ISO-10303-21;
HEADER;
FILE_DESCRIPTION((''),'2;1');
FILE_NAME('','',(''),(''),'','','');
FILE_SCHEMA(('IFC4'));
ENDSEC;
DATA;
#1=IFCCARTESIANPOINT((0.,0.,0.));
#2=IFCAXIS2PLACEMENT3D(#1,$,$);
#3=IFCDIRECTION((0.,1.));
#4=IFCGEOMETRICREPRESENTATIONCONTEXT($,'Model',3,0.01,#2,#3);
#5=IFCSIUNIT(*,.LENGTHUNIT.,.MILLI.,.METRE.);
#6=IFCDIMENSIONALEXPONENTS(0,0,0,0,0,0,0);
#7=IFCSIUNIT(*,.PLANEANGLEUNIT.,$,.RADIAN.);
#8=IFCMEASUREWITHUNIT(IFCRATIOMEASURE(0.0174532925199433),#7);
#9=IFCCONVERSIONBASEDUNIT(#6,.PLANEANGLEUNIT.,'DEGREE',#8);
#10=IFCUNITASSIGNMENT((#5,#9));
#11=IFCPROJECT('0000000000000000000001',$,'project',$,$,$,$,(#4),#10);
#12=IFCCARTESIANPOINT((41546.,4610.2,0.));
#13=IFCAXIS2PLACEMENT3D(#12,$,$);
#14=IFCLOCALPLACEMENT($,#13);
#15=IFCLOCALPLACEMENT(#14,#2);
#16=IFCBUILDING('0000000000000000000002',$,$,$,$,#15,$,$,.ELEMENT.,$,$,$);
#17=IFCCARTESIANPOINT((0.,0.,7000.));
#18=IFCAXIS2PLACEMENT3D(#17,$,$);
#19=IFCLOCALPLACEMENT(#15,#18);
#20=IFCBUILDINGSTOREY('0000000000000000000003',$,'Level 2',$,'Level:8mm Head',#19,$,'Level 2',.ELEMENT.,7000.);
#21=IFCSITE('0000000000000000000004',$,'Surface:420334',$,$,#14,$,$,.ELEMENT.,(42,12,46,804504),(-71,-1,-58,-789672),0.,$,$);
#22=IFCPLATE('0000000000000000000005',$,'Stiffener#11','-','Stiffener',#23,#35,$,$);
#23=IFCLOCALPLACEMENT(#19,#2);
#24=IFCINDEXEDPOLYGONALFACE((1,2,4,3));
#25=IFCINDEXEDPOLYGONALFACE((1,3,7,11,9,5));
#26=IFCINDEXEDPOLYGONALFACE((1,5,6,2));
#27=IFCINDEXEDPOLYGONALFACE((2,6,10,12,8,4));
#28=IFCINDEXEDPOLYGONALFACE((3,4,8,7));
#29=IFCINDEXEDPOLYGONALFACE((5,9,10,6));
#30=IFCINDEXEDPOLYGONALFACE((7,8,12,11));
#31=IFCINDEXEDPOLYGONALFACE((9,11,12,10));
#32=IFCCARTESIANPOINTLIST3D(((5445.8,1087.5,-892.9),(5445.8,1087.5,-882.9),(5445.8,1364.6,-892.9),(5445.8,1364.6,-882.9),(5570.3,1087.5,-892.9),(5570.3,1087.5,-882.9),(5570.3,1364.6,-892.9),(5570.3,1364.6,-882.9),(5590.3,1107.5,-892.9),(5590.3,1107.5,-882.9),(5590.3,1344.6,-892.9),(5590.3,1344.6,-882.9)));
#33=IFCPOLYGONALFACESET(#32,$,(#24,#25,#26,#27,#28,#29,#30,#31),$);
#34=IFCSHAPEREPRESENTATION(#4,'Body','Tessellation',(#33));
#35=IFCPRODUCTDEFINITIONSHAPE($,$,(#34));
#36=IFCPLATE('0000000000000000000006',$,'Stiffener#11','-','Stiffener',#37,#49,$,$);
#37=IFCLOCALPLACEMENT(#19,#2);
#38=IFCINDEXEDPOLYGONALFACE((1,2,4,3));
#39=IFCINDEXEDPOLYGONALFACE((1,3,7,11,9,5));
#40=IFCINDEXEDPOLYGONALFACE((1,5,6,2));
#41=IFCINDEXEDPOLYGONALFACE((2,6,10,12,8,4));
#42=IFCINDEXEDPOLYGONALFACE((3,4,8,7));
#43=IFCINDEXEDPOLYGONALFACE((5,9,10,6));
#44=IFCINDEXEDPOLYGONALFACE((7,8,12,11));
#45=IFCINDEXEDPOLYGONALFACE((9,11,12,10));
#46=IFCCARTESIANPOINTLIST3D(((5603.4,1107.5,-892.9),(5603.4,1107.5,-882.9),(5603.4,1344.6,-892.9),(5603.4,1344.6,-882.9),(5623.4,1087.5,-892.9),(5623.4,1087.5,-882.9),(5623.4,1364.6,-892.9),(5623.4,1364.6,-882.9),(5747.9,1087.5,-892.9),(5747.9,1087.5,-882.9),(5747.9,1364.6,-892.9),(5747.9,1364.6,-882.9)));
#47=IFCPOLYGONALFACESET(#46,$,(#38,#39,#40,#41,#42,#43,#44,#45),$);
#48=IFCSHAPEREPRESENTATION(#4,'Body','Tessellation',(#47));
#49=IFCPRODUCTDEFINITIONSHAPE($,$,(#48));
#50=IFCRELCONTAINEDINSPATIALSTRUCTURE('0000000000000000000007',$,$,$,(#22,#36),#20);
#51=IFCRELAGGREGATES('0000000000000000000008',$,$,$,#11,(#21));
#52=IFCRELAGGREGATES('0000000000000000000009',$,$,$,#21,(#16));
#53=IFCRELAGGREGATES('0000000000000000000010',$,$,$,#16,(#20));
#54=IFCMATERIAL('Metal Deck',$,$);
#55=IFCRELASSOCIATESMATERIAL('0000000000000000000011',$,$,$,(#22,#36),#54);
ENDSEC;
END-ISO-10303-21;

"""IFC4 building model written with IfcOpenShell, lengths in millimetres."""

from ifc_helpers import new_model, entity, si_unit, converted_unit, direction, frame, origin, origin_with_axes, place, context, project, spatial, polyline, outline, extrude, material, element, save


model = new_model("IFC4")

# Units and contexts
model_context = context("Model", 3, precision=0.01, world=origin(), true_north=direction((0.0, 1.0)))
ifc_project = project(units=[si_unit("LENGTHUNIT", "METRE", prefix="MILLI"), converted_unit("PLANEANGLEUNIT", "DEGREE", entity("IfcRatioMeasure", 0.0174532925199433), si_unit("PLANEANGLEUNIT", "RADIAN"), dimensions=[0, 0, 0, 0, 0, 0, 0])], contexts=[model_context])

# Site, building, storey
site_placement = place(None, frame((41546.0, 4610.2, 0.0)))
site = spatial("IfcSite", under=ifc_project, at=site_placement, Name="Surface:420334", CompositionType="ELEMENT", RefLatitude=(42, 12, 46, 804504), RefLongitude=(-71, -1, -58, -789672), RefElevation=0.0)
building_placement = place(site_placement, origin())
building = spatial("IfcBuilding", under=site, at=building_placement, CompositionType="ELEMENT")
storey_placement = place(building_placement, frame((0.0, 0.0, 7000.0)))
storey = spatial("IfcBuildingStorey", under=building, at=storey_placement, Name="Level 2", ObjectType="Level:8mm Head", LongName="Level 2", CompositionType="ELEMENT", Elevation=7000.0)

# Plates, openings
ifc_material_1 = material(Name="Metal Deck")
plate_1_placement = place(storey_placement, frame((5445.8, 1087.5, -882.9), z_axis=(0.0, 0.0, -1.0), x_axis=(0.0, 1.0, 0.0)))
plate_1 = element("IfcPlate", 1, at=plate_1_placement, inside=storey, material=ifc_material_1, Name="Stiffener#11", Description="-", ObjectType="Stiffener", context=model_context, shape_type="SweptSolid", body=[
    extrude(outline(polyline([(0.0, 0.0), (277.1, 0.0), (277.1, 144.5), (0.0, 144.5), (0.0, 0.0)])), origin_with_axes(), (0.0, 0.0, 1.0), 10.0),
])
opening_1_placement = place(plate_1_placement, frame((0.0, 0.0, 0.0), z_axis=(0.0, 0.0, 1.0), x_axis=(1.0, 0.0, 0.0)))
element("IfcOpeningElement", 2, at=opening_1_placement, cuts=plate_1, ObjectType="Opening", context=model_context, shape_type="SweptSolid", body=[
    extrude(outline(polyline([(277.1, 144.5), (257.1, 144.5), (277.1, 124.5), (277.1, 144.5)])), origin(), (0.0, 0.0, 1.0), 10.0),
])
opening_2_placement = place(plate_1_placement, frame((0.0, 0.0, 0.0), z_axis=(0.0, 0.0, 1.0), x_axis=(1.0, 0.0, 0.0)))
element("IfcOpeningElement", 3, at=opening_2_placement, cuts=plate_1, ObjectType="Opening", context=model_context, shape_type="SweptSolid", body=[
    extrude(outline(polyline([(0.0, 144.5), (0.0, 124.5), (20.0, 144.5), (0.0, 144.5)])), origin(), (0.0, 0.0, 1.0), 10.0),
])
plate_2_placement = place(storey_placement, frame((5603.4, 1087.5, -882.9), z_axis=(0.0, 0.0, -1.0), x_axis=(0.0, 1.0, 0.0)))
plate_2 = element("IfcPlate", 4, at=plate_2_placement, inside=storey, material=ifc_material_1, Name="Stiffener#11", Description="-", ObjectType="Stiffener", context=model_context, shape_type="SweptSolid", body=[
    extrude(outline(polyline([(0.0, 0.0), (277.1, 0.0), (277.1, 144.5), (0.0, 144.5), (0.0, 0.0)])), origin_with_axes(), (0.0, 0.0, 1.0), 10.0),
])
opening_3_placement = place(plate_2_placement, frame((0.0, 0.0, 0.0), z_axis=(0.0, 0.0, 1.0), x_axis=(1.0, 0.0, 0.0)))
element("IfcOpeningElement", 5, at=opening_3_placement, cuts=plate_2, ObjectType="Opening", context=model_context, shape_type="SweptSolid", body=[
    extrude(outline(polyline([(277.1, 0.0), (277.1, 20.0), (257.1, 0.0), (277.1, 0.0)])), origin(), (0.0, 0.0, 1.0), 10.0),
])
opening_4_placement = place(plate_2_placement, frame((0.0, 0.0, 0.0), z_axis=(0.0, 0.0, 1.0), x_axis=(1.0, 0.0, 0.0)))
element("IfcOpeningElement", 6, at=opening_4_placement, cuts=plate_2, ObjectType="Opening", context=model_context, shape_type="SweptSolid", body=[
    extrude(outline(polyline([(0.0, 0.0), (20.0, 0.0), (0.0, 20.0), (0.0, 0.0)])), origin(), (0.0, 0.0, 1.0), 10.0),
])

save(model, "model.ifc")
